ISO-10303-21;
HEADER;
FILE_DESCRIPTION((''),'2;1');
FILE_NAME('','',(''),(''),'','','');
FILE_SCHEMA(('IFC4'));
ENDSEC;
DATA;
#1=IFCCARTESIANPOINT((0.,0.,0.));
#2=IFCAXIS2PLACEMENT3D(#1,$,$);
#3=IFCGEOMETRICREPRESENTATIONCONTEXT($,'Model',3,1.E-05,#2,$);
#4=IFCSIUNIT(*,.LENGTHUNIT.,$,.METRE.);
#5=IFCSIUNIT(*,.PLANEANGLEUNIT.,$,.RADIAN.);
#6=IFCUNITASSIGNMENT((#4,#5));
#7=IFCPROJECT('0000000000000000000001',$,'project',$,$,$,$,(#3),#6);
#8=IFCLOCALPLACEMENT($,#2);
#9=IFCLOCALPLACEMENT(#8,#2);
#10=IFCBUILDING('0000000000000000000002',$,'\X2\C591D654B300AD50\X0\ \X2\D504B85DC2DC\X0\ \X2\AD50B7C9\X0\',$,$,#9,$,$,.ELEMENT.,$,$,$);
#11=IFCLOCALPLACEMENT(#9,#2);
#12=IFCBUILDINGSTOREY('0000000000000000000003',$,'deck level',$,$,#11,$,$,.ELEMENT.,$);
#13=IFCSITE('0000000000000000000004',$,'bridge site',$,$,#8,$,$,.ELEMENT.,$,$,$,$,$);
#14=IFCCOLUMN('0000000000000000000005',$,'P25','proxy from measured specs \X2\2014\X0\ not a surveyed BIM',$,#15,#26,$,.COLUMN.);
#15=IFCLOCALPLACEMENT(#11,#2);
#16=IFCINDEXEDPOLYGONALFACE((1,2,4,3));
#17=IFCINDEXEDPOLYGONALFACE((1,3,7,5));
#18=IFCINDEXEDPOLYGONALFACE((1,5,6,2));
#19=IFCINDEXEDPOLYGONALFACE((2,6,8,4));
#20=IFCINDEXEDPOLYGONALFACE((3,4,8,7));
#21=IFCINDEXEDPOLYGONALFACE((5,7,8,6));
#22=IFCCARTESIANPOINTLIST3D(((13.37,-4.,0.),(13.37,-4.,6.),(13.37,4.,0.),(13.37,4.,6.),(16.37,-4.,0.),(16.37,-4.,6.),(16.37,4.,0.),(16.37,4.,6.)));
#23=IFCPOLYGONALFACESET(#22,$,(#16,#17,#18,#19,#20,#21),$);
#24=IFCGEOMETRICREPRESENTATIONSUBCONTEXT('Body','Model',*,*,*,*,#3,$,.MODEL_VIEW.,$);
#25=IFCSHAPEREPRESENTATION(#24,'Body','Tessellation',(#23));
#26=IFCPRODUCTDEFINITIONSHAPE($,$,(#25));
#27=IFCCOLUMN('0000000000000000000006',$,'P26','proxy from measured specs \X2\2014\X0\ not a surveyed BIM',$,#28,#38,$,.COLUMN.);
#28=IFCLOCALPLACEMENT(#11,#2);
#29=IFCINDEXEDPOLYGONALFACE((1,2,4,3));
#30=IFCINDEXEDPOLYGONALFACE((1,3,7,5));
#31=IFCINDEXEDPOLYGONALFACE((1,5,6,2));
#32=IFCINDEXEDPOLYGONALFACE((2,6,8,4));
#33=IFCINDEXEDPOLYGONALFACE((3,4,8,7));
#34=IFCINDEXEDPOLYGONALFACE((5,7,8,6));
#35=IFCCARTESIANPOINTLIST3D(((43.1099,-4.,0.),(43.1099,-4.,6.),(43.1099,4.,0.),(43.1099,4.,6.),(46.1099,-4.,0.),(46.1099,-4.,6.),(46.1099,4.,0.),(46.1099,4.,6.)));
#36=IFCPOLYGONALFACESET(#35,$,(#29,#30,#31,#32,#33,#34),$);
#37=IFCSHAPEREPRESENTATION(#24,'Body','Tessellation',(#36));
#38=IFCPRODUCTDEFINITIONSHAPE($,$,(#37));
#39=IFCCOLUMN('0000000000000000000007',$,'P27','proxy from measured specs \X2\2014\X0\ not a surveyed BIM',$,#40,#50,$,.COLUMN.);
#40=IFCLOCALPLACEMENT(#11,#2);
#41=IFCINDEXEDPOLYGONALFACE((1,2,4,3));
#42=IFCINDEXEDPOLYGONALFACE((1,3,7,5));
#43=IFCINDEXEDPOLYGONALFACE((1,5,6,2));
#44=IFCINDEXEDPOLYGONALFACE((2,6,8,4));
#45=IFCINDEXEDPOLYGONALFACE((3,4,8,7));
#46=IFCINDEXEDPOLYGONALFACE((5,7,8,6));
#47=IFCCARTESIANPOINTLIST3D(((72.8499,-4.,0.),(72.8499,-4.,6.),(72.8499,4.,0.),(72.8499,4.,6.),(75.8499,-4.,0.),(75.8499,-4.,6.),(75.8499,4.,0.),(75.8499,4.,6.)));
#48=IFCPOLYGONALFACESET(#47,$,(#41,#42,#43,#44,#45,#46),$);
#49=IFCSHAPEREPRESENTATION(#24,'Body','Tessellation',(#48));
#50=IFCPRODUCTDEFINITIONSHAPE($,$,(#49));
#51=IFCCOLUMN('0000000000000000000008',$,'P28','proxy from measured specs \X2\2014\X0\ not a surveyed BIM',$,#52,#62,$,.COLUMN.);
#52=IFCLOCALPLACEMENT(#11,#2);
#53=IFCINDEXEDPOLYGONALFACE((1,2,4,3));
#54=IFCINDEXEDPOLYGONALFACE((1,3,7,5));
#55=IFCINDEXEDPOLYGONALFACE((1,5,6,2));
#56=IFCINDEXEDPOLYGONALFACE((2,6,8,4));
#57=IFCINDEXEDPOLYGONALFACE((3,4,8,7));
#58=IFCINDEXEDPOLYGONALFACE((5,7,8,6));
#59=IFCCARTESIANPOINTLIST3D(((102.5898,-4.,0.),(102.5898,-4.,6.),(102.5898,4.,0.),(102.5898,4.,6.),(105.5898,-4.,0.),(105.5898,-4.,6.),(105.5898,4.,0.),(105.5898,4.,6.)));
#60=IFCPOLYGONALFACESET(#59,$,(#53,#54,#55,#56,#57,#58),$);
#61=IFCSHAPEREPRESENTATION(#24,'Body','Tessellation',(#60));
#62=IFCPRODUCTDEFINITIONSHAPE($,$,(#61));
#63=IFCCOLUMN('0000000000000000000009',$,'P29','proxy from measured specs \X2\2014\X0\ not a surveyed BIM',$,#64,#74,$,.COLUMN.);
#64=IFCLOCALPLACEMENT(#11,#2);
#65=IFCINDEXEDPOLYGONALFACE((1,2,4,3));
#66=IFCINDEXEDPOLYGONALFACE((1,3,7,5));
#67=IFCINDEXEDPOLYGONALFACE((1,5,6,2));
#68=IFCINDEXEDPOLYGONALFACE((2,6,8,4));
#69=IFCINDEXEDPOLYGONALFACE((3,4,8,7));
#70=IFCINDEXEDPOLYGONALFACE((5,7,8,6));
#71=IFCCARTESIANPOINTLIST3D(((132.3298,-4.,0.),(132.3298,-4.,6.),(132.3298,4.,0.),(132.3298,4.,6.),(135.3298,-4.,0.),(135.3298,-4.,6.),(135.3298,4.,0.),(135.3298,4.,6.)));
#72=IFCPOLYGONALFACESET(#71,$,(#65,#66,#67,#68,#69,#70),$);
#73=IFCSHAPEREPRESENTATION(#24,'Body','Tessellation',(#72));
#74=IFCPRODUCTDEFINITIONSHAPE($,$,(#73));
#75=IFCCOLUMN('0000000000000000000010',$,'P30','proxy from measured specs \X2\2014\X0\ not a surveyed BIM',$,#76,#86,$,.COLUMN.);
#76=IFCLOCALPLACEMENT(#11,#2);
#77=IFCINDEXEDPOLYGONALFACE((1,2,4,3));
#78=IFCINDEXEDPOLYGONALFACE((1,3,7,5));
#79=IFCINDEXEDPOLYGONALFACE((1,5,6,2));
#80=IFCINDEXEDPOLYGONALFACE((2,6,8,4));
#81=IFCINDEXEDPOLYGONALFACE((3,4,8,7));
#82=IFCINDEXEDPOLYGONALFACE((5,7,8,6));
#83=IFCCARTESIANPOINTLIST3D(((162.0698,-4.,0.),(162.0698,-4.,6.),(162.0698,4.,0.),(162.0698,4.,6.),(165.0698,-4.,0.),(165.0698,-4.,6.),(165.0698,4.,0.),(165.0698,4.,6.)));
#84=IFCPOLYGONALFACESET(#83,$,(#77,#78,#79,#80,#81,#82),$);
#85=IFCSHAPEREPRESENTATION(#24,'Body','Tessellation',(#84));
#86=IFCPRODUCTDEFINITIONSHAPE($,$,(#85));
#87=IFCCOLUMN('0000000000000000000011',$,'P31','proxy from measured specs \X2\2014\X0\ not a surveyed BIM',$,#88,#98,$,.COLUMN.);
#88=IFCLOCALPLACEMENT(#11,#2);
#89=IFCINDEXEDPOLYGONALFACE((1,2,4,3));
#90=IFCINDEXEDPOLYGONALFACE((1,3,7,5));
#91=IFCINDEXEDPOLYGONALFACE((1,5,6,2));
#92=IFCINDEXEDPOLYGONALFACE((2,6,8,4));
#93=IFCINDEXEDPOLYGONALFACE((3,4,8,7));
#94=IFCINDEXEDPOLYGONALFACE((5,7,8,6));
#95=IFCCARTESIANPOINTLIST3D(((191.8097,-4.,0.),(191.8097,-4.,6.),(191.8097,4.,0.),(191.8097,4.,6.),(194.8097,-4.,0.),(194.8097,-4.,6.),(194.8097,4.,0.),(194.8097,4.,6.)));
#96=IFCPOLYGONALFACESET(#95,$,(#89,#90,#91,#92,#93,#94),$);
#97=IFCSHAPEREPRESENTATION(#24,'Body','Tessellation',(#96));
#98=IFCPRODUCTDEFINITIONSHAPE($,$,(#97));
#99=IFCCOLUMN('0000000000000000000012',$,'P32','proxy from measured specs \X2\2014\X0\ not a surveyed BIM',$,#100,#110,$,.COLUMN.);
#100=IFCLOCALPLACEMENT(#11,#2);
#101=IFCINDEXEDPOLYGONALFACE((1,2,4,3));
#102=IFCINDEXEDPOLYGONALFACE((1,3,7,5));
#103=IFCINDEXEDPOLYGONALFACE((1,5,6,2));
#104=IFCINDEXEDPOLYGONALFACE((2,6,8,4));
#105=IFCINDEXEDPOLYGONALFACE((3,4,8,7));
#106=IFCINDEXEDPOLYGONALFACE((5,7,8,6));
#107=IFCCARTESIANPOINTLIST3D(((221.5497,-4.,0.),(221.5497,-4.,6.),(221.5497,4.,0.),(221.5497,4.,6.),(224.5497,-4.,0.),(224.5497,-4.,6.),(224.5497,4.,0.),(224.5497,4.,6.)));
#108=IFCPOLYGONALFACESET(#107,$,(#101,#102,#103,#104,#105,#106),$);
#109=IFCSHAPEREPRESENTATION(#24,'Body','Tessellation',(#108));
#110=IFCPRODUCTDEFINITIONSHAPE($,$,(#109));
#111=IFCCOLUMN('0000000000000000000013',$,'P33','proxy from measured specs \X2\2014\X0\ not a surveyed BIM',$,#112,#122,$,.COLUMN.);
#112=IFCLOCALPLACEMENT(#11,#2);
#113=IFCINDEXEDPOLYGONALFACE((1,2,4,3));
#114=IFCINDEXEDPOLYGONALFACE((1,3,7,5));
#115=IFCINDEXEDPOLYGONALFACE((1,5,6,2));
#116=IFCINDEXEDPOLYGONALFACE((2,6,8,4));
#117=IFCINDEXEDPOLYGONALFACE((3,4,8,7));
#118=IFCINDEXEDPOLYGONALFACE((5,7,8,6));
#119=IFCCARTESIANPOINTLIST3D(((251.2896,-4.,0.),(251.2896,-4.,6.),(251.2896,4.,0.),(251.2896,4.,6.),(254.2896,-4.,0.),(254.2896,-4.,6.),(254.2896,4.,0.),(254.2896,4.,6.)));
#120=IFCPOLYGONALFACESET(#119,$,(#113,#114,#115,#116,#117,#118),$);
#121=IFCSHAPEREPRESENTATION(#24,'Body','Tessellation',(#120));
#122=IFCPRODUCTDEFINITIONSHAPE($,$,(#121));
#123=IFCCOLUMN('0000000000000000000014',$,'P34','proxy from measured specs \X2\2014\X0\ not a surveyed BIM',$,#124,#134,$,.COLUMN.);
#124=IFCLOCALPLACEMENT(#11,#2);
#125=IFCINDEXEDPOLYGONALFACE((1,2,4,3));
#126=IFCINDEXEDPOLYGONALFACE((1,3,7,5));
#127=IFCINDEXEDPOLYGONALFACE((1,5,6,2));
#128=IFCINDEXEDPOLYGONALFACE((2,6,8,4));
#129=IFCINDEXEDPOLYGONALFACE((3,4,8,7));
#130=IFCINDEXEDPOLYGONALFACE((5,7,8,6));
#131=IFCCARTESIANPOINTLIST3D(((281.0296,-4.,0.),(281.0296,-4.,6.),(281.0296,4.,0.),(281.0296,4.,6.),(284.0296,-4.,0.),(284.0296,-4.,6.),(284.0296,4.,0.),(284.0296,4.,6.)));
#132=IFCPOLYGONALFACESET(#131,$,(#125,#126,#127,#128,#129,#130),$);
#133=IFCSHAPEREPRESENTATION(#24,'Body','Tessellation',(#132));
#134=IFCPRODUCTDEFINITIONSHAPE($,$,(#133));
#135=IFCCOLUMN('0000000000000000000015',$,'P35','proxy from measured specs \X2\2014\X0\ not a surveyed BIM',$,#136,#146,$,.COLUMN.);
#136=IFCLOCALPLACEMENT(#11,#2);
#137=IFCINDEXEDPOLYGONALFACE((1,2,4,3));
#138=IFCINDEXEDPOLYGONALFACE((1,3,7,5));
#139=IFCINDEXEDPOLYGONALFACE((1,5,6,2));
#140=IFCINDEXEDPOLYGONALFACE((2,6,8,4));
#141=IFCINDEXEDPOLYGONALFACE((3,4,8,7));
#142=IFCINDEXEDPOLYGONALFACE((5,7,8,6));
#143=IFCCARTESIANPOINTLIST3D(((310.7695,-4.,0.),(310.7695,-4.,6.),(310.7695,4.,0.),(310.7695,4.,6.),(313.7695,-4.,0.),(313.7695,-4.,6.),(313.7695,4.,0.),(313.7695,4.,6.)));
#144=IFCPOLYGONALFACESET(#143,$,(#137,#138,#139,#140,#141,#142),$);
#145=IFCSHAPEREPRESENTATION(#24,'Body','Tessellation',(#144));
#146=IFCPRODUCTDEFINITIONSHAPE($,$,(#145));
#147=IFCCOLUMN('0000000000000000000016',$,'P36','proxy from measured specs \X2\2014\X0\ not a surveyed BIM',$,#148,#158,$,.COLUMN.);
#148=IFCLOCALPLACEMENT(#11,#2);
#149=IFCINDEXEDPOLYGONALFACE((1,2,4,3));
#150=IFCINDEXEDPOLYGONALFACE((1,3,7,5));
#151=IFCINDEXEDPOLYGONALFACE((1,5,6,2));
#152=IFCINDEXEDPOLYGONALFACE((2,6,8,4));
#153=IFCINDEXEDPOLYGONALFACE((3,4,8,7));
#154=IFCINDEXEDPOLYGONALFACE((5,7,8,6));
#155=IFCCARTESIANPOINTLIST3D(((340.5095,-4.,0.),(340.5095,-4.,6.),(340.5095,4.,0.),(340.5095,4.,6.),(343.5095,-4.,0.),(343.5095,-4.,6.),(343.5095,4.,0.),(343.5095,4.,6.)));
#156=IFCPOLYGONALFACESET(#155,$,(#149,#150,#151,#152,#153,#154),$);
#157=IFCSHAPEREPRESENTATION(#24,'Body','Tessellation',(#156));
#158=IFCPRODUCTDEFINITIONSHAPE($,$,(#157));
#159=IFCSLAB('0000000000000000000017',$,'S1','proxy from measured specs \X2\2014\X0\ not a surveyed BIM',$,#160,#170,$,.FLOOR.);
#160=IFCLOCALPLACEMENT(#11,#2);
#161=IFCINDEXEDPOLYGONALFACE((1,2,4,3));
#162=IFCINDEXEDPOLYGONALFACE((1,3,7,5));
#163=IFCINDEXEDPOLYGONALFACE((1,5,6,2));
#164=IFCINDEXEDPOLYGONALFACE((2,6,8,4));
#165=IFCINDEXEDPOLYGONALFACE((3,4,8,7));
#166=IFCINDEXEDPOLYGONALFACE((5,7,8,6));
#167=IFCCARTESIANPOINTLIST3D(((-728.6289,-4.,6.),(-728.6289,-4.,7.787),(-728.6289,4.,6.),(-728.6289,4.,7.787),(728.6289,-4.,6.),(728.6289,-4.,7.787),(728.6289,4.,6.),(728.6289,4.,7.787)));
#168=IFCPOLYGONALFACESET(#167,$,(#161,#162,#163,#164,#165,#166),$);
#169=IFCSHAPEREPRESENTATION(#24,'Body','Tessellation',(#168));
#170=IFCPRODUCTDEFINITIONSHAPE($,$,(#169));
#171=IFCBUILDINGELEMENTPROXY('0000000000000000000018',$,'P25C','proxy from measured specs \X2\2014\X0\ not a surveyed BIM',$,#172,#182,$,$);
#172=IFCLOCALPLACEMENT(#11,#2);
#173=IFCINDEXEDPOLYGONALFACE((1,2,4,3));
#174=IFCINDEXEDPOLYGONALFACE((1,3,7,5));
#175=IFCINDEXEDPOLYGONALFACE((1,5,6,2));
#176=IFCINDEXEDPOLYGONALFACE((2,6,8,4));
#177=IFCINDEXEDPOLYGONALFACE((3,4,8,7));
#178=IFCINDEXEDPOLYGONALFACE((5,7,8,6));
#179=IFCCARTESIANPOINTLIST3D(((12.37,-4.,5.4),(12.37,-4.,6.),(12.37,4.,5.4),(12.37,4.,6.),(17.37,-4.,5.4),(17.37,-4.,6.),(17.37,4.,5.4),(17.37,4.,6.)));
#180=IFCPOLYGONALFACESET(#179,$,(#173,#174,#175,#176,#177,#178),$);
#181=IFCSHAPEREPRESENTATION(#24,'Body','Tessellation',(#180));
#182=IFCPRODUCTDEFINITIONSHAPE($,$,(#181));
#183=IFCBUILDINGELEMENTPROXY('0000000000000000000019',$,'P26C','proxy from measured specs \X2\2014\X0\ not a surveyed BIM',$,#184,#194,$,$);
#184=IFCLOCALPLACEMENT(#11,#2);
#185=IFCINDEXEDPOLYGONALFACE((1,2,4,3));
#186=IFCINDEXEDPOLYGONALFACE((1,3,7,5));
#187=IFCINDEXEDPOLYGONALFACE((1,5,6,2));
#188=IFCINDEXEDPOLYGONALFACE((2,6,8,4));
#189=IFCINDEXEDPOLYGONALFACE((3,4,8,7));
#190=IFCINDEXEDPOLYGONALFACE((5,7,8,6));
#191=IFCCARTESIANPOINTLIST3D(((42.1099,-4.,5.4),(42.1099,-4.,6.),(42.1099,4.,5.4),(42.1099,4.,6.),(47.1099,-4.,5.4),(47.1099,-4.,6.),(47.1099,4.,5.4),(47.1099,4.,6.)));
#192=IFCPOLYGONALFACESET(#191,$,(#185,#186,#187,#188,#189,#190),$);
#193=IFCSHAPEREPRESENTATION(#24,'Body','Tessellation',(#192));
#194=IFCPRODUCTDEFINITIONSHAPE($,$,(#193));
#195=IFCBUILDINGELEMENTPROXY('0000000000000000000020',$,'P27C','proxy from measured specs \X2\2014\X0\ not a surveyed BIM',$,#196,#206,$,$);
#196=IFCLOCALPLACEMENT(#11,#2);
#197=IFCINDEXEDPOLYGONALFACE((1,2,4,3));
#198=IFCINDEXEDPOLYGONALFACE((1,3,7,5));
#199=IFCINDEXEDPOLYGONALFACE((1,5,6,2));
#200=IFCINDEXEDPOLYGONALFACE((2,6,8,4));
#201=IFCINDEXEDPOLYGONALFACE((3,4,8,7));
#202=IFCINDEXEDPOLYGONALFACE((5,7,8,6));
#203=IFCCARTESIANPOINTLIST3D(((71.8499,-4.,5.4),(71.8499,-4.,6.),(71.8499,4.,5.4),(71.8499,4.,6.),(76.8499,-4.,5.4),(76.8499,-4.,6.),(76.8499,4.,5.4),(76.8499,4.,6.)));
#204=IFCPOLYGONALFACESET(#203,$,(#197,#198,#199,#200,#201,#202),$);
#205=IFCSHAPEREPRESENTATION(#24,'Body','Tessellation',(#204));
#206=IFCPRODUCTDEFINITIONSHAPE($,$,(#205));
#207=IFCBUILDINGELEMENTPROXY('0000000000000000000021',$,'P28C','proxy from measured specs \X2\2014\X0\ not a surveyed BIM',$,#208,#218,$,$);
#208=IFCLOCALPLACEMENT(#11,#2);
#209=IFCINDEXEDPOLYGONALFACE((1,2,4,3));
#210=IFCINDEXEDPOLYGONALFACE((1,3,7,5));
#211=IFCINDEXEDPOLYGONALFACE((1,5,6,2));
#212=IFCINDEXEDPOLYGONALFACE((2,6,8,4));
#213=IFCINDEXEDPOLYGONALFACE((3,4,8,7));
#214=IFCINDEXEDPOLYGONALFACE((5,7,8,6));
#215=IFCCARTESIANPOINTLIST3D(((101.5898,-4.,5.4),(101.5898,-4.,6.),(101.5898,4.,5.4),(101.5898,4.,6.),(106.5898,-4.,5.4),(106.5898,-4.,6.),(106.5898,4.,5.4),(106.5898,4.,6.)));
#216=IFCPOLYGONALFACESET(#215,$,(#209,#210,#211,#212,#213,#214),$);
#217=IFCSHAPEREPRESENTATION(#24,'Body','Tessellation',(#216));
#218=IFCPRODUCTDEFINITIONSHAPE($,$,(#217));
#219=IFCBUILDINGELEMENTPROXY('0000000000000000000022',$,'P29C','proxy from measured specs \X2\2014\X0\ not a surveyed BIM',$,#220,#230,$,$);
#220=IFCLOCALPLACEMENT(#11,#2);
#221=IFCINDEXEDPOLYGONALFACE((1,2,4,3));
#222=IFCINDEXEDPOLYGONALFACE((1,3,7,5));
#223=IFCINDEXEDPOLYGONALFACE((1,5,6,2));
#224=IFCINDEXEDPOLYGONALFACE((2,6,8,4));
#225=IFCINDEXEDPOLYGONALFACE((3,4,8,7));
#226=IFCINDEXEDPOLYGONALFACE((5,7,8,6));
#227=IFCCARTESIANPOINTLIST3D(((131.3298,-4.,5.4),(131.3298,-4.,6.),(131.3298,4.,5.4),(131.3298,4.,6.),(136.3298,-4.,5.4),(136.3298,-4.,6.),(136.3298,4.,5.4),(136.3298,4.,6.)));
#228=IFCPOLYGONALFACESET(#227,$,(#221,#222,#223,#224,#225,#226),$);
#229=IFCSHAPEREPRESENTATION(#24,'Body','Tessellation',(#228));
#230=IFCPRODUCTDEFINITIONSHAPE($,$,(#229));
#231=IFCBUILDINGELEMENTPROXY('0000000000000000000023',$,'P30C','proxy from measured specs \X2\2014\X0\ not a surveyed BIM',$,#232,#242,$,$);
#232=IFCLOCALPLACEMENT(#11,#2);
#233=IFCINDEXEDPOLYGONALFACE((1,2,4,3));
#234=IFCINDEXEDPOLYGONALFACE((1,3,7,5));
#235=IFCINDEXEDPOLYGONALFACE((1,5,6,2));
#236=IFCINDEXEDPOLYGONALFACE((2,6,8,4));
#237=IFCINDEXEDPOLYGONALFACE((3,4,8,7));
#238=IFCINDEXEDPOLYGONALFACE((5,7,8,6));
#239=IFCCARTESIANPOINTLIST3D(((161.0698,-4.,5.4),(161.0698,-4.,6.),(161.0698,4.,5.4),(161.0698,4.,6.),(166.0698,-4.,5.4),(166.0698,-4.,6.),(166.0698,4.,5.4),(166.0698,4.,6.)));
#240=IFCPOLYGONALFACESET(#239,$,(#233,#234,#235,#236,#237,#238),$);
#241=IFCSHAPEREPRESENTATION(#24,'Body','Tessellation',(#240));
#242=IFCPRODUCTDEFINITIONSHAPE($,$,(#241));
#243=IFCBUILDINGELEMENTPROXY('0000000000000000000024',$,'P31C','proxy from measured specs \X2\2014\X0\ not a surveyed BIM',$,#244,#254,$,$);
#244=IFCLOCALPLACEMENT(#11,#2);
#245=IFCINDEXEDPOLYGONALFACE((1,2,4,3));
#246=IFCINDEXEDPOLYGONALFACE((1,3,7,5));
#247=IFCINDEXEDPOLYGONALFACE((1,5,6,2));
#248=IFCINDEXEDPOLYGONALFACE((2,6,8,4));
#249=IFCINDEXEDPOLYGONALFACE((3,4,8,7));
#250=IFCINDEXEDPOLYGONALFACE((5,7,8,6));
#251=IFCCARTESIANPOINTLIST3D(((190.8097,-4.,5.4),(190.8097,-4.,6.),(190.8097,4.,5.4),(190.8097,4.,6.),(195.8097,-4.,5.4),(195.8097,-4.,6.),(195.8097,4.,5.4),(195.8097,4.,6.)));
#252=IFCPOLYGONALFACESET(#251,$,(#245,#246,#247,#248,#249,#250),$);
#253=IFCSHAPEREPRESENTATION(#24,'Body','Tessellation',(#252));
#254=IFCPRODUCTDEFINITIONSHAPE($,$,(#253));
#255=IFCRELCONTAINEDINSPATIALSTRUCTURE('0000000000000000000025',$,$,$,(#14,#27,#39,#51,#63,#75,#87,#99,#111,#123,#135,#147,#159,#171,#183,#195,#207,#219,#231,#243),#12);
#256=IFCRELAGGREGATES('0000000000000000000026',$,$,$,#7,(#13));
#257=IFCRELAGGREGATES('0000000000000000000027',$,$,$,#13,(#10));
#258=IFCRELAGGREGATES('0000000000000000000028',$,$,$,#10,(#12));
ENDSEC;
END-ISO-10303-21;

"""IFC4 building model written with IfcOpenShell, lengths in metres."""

from ifc_helpers import new_model, si_unit, frame, origin, origin_2d, place, context, subcontext, project, spatial, rectangle, extrude, element, save


model = new_model("IFC4")

# Units and contexts
model_context = context("Model", 3, precision=1e-05, world=origin())
body_context = subcontext(model_context, "Body", "Model", "MODEL_VIEW")
ifc_project = project(units=[si_unit("LENGTHUNIT", "METRE"), si_unit("PLANEANGLEUNIT", "RADIAN")], contexts=[model_context])

# Site, building, storey
site_placement = place(None, origin())
site = spatial("IfcSite", under=ifc_project, at=site_placement, Name="bridge site", CompositionType="ELEMENT")
building_placement = place(site_placement, origin())
building = spatial("IfcBuilding", under=site, at=building_placement, Name="양화대교 프록시 교량", CompositionType="ELEMENT")
storey_placement = place(building_placement, origin())
storey = spatial("IfcBuildingStorey", under=building, at=storey_placement, Name="deck level", CompositionType="ELEMENT")

# Columns
for number, where, name in (
    (1, (14.87, 0.0, 0.0), "P25"),
    (2, (44.6099, 0.0, 0.0), "P26"),
    (3, (74.3499, 0.0, 0.0), "P27"),
    (4, (104.0898, 0.0, 0.0), "P28"),
    (5, (133.8298, 0.0, 0.0), "P29"),
    (6, (163.5698, 0.0, 0.0), "P30"),
    (7, (193.3097, 0.0, 0.0), "P31"),
    (8, (223.0497, 0.0, 0.0), "P32"),
    (9, (252.7896, 0.0, 0.0), "P33"),
    (10, (282.5296, 0.0, 0.0), "P34"),
    (11, (312.2695, 0.0, 0.0), "P35"),
    (12, (342.0095, 0.0, 0.0), "P36"),
):
    element("IfcColumn", number, at=place(storey_placement, frame(where)), inside=storey, Name=name, Description="proxy from measured specs — not a surveyed BIM", PredefinedType="COLUMN", context=body_context, shape_type="SweptSolid", body=[
        extrude(rectangle(XDim=3.0, YDim=8.0, at=origin_2d()), origin(), (0.0, 0.0, 1.0), 6.0),
    ])

# Slab
slab_placement = place(storey_placement, frame((0.0, 0.0, 6.0)))
element("IfcSlab", 13, at=slab_placement, inside=storey, Name="S1", Description="proxy from measured specs — not a surveyed BIM", PredefinedType="FLOOR", context=body_context, shape_type="SweptSolid", body=[
    extrude(rectangle(XDim=1457.2578, YDim=8.0, at=origin_2d()), origin(), (0.0, 0.0, 1.0), 1.787),
])

# Building element proxies
for number, where, name in (
    (14, (14.87, 0.0, 5.4), "P25C"),
    (15, (44.6099, 0.0, 5.4), "P26C"),
    (16, (74.3499, 0.0, 5.4), "P27C"),
    (17, (104.0898, 0.0, 5.4), "P28C"),
    (18, (133.8298, 0.0, 5.4), "P29C"),
    (19, (163.5698, 0.0, 5.4), "P30C"),
    (20, (193.3097, 0.0, 5.4), "P31C"),
):
    element("IfcBuildingElementProxy", number, at=place(storey_placement, frame(where)), inside=storey, Name=name, Description="proxy from measured specs — not a surveyed BIM", context=body_context, shape_type="SweptSolid", body=[
        extrude(rectangle(XDim=5.0, YDim=8.0, at=origin_2d()), origin(), (0.0, 0.0, 1.0), 0.6),
    ])

save(model, "model.ifc")
